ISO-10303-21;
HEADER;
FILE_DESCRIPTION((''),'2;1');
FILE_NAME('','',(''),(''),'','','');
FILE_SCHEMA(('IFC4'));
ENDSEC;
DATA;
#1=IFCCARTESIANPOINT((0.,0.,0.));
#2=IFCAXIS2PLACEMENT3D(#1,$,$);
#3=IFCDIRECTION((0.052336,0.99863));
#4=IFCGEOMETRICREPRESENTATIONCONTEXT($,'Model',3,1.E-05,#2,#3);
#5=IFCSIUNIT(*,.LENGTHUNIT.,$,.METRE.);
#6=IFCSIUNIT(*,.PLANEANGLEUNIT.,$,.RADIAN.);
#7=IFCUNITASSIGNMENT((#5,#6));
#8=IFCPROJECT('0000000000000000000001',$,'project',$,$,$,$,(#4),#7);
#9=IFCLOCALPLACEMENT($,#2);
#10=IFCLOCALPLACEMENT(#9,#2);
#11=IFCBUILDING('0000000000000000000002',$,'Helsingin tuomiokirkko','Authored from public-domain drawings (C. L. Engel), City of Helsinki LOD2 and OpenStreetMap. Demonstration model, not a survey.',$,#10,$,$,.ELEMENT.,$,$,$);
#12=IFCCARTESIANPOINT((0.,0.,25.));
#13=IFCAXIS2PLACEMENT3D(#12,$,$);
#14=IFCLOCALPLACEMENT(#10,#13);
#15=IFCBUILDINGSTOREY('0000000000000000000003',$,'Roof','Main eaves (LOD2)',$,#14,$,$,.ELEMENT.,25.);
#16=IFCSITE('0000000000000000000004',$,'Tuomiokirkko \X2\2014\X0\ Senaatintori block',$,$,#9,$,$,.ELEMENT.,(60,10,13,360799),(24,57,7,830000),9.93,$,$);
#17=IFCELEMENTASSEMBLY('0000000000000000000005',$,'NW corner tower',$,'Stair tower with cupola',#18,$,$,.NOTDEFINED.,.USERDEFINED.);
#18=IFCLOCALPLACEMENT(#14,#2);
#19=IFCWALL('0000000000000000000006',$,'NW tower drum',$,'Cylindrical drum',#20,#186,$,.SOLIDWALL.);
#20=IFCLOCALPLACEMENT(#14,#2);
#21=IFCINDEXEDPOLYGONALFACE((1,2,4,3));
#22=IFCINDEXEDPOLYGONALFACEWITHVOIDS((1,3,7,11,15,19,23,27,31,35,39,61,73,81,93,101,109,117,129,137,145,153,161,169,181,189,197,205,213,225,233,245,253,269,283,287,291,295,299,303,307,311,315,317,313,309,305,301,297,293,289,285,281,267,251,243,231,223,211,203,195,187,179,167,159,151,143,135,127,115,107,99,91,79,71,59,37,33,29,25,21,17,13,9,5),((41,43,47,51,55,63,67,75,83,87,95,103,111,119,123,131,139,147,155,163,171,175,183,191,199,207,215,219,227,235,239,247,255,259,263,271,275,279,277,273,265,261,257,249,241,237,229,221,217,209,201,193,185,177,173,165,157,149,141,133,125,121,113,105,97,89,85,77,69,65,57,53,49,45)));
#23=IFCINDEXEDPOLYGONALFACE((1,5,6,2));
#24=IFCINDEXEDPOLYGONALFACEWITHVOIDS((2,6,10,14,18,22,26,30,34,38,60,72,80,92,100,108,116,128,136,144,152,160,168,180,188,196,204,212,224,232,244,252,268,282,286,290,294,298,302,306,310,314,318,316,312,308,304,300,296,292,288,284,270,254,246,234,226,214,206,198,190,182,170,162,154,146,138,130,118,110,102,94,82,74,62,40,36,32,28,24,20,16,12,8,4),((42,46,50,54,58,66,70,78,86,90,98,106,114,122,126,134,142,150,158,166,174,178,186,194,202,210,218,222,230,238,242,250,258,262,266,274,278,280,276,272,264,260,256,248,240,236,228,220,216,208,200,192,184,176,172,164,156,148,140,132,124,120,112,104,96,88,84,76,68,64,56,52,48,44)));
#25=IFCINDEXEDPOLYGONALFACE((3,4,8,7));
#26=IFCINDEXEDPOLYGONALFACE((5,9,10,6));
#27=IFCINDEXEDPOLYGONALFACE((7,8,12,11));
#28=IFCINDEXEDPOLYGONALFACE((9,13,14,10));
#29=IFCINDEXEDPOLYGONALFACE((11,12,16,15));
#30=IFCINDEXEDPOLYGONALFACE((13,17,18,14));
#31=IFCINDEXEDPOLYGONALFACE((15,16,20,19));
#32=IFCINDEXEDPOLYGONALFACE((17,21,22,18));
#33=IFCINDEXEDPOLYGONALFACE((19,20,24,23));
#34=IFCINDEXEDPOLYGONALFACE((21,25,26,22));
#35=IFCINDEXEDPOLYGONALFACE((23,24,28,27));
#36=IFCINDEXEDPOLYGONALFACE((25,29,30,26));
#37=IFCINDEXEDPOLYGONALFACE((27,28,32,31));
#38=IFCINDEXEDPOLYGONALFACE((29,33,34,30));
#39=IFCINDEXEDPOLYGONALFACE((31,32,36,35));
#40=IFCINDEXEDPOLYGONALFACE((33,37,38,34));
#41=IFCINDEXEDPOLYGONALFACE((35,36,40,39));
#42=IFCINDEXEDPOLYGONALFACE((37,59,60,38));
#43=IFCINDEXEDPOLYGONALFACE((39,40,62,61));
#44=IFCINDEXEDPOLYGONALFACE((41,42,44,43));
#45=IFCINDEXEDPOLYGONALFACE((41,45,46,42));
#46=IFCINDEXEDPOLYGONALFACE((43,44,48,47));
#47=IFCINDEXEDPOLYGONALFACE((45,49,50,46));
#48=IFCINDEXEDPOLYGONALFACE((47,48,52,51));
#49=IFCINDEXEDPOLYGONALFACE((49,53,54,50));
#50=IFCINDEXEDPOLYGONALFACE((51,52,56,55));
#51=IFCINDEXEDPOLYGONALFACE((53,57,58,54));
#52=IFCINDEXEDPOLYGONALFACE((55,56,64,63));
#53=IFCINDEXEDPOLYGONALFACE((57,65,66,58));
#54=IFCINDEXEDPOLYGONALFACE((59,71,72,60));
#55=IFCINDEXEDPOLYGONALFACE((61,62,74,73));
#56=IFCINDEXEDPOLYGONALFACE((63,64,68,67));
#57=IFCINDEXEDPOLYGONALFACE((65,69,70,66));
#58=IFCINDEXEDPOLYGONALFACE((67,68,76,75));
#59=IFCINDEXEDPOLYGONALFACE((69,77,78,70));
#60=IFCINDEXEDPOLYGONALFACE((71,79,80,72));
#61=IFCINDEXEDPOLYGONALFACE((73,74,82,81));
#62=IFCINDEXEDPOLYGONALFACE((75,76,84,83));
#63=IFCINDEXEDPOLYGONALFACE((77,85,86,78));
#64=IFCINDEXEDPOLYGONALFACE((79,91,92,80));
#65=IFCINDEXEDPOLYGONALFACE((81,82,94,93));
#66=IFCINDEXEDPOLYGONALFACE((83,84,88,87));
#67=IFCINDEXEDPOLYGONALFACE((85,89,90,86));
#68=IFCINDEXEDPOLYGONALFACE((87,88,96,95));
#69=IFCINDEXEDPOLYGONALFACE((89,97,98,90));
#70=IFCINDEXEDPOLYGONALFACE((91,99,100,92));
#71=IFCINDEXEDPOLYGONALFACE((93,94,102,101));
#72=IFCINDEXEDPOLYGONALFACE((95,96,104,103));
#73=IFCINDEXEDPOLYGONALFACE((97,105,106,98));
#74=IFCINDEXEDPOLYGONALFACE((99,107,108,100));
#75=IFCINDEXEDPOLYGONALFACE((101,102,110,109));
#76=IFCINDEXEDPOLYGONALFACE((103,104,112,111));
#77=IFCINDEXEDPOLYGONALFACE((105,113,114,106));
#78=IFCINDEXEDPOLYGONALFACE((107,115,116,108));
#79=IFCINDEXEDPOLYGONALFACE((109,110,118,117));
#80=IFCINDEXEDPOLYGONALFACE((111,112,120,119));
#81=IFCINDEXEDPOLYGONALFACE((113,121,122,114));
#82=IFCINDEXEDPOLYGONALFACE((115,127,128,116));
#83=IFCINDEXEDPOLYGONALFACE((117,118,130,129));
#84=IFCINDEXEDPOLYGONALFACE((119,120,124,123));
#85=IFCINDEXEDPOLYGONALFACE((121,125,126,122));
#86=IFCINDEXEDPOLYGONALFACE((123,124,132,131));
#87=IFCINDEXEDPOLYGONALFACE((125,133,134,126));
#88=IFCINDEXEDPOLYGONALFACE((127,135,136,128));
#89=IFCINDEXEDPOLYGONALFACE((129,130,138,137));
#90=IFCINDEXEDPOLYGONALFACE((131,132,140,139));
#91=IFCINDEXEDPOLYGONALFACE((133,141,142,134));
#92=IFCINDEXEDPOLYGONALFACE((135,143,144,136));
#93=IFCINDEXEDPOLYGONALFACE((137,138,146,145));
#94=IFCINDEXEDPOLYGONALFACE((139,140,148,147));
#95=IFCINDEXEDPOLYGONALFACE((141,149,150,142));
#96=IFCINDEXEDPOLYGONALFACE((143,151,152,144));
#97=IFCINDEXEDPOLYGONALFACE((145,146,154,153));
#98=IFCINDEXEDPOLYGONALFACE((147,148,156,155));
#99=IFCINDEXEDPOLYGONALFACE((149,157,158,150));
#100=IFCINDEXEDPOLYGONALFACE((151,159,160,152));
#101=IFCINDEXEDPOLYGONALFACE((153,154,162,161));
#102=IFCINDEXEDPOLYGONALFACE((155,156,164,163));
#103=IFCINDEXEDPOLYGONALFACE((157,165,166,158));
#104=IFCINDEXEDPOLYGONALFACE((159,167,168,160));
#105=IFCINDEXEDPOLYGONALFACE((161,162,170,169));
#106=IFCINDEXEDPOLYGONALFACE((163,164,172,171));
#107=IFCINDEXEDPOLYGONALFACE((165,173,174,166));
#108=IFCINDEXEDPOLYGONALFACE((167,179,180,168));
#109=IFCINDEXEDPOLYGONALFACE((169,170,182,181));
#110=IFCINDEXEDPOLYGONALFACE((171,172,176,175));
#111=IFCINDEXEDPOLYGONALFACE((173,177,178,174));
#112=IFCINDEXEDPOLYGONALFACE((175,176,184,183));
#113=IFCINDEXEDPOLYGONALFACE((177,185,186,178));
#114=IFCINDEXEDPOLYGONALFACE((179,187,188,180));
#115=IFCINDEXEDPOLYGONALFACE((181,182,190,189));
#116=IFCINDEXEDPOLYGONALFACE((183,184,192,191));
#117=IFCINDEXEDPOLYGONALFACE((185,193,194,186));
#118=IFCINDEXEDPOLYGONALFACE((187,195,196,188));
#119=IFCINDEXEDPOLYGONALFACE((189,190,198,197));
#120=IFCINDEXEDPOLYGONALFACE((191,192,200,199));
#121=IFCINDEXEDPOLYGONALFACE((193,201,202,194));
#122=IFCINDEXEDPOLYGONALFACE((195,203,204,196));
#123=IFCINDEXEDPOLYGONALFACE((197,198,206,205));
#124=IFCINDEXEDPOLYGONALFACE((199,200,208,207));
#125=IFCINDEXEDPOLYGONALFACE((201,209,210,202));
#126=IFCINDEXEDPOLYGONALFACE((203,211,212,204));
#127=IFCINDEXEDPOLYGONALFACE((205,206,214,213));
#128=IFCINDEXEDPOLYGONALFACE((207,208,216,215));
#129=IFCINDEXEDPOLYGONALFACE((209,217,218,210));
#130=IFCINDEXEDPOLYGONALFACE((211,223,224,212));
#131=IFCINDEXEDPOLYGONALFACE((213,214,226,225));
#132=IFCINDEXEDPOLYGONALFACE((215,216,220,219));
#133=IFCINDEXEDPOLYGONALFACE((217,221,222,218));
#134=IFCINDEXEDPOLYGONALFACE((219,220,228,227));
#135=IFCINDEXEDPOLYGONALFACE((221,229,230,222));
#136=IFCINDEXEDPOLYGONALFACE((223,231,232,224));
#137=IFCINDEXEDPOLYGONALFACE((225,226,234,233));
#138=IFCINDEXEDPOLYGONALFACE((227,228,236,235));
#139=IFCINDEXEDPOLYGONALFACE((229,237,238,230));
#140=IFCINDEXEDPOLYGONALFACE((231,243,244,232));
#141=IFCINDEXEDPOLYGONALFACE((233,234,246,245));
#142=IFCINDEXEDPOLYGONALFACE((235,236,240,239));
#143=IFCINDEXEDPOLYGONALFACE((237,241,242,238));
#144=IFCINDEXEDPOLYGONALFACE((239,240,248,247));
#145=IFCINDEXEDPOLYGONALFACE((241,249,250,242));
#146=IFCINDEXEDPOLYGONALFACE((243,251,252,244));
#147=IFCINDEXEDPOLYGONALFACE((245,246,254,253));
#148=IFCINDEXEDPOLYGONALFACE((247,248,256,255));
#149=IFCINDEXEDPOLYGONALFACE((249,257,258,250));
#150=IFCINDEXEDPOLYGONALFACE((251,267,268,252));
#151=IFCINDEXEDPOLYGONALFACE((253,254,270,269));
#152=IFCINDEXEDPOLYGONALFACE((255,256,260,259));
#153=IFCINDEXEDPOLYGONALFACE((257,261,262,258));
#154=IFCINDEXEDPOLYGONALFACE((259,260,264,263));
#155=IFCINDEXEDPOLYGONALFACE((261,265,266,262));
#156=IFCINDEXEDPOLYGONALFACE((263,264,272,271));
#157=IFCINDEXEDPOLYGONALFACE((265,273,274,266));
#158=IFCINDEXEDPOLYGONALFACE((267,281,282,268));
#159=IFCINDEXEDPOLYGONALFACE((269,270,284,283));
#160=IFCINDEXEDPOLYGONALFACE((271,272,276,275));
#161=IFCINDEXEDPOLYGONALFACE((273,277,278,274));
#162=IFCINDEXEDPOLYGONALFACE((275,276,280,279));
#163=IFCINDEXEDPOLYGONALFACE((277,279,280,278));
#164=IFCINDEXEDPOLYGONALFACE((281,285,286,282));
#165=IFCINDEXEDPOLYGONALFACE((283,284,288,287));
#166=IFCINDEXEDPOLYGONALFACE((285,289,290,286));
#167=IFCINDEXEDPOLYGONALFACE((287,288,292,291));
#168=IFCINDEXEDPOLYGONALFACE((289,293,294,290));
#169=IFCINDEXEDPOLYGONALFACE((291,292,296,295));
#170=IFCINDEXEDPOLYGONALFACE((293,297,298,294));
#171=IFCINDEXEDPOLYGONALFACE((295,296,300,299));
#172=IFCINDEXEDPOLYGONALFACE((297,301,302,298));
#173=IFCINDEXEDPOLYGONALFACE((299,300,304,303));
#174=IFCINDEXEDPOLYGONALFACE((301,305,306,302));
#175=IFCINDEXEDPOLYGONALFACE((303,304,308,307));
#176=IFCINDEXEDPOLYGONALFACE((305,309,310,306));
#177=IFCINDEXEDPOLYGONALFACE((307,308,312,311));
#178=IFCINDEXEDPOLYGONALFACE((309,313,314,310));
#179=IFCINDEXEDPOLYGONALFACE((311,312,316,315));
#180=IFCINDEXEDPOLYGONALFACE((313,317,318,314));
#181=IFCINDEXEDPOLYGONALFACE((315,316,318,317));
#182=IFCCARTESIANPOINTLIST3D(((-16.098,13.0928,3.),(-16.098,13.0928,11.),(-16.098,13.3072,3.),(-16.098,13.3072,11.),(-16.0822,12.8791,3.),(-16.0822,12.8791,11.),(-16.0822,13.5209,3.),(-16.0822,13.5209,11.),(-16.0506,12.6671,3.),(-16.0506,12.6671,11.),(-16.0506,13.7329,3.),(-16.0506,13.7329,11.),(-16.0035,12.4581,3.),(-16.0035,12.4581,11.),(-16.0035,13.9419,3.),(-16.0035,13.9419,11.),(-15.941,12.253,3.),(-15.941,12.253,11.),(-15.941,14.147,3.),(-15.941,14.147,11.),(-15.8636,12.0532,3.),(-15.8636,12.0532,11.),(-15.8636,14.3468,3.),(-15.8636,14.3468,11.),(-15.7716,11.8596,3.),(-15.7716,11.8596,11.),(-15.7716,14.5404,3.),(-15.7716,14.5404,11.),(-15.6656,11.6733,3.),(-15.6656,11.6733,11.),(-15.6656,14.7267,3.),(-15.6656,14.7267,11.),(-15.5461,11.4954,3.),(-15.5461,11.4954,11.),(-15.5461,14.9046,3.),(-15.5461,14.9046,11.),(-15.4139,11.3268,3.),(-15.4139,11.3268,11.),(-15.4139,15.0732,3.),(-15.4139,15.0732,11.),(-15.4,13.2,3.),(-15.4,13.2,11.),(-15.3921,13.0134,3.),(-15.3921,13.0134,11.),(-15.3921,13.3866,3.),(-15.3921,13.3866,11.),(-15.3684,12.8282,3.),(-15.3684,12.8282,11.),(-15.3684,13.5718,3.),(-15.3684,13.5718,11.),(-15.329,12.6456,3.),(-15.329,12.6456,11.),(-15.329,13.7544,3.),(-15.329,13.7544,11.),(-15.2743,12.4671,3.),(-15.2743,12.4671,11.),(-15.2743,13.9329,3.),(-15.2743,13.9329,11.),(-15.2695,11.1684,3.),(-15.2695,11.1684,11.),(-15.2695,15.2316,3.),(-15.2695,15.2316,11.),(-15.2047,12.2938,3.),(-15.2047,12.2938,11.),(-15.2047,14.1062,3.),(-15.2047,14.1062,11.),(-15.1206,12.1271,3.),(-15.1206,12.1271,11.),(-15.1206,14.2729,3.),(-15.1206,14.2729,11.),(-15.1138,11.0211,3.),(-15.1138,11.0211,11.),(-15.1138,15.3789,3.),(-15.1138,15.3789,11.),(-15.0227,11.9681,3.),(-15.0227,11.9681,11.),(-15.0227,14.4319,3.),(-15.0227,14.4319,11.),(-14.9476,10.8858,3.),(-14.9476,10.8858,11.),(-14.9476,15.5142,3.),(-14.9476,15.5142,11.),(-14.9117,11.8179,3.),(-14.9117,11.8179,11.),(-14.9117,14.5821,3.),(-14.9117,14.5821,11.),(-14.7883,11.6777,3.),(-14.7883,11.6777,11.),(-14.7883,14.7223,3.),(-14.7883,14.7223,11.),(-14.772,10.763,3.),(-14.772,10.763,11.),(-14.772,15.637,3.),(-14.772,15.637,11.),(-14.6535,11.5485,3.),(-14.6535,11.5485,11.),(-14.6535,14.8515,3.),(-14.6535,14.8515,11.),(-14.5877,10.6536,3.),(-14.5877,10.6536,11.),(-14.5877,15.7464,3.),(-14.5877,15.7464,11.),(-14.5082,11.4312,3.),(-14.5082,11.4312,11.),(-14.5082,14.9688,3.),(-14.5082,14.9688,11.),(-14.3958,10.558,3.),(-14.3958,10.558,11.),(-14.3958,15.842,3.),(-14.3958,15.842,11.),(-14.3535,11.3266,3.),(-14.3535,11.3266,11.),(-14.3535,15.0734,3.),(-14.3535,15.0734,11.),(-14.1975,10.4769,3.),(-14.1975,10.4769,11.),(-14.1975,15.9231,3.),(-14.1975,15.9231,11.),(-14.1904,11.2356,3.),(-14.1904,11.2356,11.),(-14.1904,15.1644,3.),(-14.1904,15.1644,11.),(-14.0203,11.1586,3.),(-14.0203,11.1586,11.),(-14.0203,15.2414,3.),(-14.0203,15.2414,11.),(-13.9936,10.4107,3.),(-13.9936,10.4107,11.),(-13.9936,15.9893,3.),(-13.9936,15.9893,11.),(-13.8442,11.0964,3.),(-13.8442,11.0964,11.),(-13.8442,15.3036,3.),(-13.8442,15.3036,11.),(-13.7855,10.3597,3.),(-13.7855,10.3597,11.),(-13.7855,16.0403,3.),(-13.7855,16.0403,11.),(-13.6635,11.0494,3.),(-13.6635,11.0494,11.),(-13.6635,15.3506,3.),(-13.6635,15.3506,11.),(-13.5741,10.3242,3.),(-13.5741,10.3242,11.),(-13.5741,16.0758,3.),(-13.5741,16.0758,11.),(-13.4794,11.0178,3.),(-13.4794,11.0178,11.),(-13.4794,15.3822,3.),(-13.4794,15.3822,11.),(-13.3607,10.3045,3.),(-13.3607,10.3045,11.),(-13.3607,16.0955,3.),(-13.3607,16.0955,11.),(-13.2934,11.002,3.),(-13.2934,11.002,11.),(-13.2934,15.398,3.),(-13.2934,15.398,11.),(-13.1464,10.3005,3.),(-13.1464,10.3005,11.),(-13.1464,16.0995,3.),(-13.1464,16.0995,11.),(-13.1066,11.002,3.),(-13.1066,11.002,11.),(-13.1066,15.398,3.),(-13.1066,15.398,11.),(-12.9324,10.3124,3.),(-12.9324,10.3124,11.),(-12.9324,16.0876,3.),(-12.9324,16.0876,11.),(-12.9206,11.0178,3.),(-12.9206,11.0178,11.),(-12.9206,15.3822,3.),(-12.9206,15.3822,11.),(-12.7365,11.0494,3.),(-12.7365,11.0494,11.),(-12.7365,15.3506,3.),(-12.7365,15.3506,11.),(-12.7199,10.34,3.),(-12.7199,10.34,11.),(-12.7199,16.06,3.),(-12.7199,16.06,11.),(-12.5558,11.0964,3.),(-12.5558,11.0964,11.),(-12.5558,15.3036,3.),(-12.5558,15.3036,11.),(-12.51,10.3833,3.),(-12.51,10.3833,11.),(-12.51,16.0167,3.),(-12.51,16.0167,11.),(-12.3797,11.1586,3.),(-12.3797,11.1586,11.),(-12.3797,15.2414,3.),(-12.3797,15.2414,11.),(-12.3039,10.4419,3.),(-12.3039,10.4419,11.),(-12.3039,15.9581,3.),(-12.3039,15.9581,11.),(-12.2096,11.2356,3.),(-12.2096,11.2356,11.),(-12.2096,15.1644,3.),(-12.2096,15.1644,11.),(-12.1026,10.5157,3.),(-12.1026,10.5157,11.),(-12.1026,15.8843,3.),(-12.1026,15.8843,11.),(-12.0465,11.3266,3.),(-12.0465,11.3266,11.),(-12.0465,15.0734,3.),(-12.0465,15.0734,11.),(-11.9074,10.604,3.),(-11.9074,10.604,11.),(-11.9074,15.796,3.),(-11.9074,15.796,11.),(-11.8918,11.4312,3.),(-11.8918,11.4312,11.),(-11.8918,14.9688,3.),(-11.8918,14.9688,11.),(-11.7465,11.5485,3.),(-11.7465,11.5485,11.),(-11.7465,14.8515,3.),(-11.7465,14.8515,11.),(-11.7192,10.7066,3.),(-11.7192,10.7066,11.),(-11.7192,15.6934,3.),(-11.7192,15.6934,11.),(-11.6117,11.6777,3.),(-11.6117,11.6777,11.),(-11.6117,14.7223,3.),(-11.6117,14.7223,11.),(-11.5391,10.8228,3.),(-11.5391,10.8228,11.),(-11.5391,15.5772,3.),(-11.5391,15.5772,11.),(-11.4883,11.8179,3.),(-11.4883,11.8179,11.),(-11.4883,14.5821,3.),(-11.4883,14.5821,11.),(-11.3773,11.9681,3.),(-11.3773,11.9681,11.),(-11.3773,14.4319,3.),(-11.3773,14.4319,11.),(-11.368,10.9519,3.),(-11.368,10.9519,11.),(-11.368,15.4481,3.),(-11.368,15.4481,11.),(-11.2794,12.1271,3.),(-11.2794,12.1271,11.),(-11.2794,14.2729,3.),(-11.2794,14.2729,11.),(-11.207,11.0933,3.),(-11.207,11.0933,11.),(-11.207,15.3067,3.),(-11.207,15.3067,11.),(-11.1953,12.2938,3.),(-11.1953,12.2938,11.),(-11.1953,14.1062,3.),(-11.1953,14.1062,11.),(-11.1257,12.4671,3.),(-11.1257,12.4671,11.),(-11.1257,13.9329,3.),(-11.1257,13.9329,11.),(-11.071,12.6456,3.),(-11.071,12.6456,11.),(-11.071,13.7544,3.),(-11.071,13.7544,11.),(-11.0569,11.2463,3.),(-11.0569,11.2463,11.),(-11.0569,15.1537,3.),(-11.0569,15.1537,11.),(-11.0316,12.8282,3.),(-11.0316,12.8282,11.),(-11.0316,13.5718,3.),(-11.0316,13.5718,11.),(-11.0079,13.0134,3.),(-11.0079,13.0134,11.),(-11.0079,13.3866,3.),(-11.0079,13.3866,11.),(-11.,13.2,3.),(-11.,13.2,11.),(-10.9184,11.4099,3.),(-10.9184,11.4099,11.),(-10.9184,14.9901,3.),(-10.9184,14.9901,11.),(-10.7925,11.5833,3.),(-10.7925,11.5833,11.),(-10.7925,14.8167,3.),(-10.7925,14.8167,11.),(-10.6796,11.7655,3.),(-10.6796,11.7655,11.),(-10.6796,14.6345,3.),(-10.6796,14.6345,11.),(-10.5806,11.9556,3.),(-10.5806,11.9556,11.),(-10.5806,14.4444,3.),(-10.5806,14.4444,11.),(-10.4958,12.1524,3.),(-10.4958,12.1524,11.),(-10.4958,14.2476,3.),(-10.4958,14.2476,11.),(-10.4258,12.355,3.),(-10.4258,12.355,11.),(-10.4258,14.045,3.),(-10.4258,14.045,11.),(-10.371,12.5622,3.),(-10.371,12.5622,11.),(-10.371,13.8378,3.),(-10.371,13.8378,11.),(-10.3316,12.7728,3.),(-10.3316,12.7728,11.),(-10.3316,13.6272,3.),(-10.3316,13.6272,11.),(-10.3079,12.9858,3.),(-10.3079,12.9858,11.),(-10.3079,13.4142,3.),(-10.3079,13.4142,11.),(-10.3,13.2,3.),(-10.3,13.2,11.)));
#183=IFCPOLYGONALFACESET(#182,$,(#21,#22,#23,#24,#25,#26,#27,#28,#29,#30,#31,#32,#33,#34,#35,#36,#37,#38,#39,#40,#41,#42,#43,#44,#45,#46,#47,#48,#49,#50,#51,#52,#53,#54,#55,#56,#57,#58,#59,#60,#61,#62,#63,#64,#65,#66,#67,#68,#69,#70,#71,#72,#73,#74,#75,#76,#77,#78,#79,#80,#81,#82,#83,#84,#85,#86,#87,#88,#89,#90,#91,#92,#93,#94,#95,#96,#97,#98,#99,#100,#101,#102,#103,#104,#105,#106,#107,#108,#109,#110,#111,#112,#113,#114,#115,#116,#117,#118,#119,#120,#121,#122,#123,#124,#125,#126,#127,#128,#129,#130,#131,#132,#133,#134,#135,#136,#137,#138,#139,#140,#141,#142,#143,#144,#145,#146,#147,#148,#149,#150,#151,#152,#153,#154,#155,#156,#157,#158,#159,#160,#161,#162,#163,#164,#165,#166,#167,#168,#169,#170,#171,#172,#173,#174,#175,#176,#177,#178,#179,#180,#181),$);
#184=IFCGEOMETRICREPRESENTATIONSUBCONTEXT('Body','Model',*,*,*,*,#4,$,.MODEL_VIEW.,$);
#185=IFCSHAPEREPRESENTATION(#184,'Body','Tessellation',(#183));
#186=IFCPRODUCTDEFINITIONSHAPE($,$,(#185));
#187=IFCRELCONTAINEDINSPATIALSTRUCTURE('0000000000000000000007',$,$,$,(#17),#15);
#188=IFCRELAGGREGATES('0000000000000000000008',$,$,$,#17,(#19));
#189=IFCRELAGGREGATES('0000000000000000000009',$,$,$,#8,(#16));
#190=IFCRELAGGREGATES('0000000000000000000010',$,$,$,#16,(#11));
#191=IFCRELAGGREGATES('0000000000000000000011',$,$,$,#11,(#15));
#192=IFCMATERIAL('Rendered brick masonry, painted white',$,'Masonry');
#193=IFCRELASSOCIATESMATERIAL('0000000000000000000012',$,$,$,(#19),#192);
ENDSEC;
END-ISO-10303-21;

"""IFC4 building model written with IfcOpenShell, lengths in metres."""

from ifc_helpers import new_model, si_unit, direction, frame, origin, origin_2d_with_axis, place, context, subcontext, project, spatial, hollow_circle, extrude, material, element, aggregate, save


model = new_model("IFC4")

# Units and contexts
model_context = context("Model", 3, precision=1e-05, world=origin(), true_north=direction((0.052336, 0.99863)))
body_context = subcontext(model_context, "Body", "Model", "MODEL_VIEW")
ifc_project = project(units=[si_unit("LENGTHUNIT", "METRE"), si_unit("PLANEANGLEUNIT", "RADIAN")], contexts=[model_context])

# Site, building, storey
site_placement = place(None, origin())
site = spatial("IfcSite", under=ifc_project, at=site_placement, Name="Tuomiokirkko — Senaatintori block", CompositionType="ELEMENT", RefLatitude=(60, 10, 13, 360799), RefLongitude=(24, 57, 7, 830000), RefElevation=9.93)
building_placement = place(site_placement, origin())
building = spatial("IfcBuilding", under=site, at=building_placement, Name="Helsingin tuomiokirkko", Description="Authored from public-domain drawings (C. L. Engel), City of Helsinki LOD2 and OpenStreetMap. Demonstration model, not a survey.", CompositionType="ELEMENT")
storey_placement = place(building_placement, frame((0.0, 0.0, 25.0)))
storey = spatial("IfcBuildingStorey", under=building, at=storey_placement, Name="Roof", Description="Main eaves (LOD2)", CompositionType="ELEMENT", Elevation=25.0)

# Element assembly
assembly_1_placement = place(building_placement, origin())
assembly_1 = element("IfcElementAssembly", 1, at=assembly_1_placement, inside=storey, Name="NW corner tower", ObjectType="Stair tower with cupola", AssemblyPlace="NOTDEFINED", PredefinedType="USERDEFINED")

# Shared definitions
ifc_material_1 = material(Name="Rendered brick masonry, painted white", Category="Masonry")

# Wall
wall_1_placement = place(building_placement, origin())
wall_1 = element("IfcWall", 2, at=wall_1_placement, material=ifc_material_1, Name="NW tower drum", ObjectType="Cylindrical drum", PredefinedType="SOLIDWALL", context=body_context, shape_type="SweptSolid", body=[
    extrude(hollow_circle(Radius=2.9, WallThickness=0.7, at=origin_2d_with_axis()), frame((-13.2, 13.2, 28.0)), (0.0, 0.0, 1.0), 8.0),
])
aggregate(assembly_1, [wall_1])

save(model, "model.ifc")
